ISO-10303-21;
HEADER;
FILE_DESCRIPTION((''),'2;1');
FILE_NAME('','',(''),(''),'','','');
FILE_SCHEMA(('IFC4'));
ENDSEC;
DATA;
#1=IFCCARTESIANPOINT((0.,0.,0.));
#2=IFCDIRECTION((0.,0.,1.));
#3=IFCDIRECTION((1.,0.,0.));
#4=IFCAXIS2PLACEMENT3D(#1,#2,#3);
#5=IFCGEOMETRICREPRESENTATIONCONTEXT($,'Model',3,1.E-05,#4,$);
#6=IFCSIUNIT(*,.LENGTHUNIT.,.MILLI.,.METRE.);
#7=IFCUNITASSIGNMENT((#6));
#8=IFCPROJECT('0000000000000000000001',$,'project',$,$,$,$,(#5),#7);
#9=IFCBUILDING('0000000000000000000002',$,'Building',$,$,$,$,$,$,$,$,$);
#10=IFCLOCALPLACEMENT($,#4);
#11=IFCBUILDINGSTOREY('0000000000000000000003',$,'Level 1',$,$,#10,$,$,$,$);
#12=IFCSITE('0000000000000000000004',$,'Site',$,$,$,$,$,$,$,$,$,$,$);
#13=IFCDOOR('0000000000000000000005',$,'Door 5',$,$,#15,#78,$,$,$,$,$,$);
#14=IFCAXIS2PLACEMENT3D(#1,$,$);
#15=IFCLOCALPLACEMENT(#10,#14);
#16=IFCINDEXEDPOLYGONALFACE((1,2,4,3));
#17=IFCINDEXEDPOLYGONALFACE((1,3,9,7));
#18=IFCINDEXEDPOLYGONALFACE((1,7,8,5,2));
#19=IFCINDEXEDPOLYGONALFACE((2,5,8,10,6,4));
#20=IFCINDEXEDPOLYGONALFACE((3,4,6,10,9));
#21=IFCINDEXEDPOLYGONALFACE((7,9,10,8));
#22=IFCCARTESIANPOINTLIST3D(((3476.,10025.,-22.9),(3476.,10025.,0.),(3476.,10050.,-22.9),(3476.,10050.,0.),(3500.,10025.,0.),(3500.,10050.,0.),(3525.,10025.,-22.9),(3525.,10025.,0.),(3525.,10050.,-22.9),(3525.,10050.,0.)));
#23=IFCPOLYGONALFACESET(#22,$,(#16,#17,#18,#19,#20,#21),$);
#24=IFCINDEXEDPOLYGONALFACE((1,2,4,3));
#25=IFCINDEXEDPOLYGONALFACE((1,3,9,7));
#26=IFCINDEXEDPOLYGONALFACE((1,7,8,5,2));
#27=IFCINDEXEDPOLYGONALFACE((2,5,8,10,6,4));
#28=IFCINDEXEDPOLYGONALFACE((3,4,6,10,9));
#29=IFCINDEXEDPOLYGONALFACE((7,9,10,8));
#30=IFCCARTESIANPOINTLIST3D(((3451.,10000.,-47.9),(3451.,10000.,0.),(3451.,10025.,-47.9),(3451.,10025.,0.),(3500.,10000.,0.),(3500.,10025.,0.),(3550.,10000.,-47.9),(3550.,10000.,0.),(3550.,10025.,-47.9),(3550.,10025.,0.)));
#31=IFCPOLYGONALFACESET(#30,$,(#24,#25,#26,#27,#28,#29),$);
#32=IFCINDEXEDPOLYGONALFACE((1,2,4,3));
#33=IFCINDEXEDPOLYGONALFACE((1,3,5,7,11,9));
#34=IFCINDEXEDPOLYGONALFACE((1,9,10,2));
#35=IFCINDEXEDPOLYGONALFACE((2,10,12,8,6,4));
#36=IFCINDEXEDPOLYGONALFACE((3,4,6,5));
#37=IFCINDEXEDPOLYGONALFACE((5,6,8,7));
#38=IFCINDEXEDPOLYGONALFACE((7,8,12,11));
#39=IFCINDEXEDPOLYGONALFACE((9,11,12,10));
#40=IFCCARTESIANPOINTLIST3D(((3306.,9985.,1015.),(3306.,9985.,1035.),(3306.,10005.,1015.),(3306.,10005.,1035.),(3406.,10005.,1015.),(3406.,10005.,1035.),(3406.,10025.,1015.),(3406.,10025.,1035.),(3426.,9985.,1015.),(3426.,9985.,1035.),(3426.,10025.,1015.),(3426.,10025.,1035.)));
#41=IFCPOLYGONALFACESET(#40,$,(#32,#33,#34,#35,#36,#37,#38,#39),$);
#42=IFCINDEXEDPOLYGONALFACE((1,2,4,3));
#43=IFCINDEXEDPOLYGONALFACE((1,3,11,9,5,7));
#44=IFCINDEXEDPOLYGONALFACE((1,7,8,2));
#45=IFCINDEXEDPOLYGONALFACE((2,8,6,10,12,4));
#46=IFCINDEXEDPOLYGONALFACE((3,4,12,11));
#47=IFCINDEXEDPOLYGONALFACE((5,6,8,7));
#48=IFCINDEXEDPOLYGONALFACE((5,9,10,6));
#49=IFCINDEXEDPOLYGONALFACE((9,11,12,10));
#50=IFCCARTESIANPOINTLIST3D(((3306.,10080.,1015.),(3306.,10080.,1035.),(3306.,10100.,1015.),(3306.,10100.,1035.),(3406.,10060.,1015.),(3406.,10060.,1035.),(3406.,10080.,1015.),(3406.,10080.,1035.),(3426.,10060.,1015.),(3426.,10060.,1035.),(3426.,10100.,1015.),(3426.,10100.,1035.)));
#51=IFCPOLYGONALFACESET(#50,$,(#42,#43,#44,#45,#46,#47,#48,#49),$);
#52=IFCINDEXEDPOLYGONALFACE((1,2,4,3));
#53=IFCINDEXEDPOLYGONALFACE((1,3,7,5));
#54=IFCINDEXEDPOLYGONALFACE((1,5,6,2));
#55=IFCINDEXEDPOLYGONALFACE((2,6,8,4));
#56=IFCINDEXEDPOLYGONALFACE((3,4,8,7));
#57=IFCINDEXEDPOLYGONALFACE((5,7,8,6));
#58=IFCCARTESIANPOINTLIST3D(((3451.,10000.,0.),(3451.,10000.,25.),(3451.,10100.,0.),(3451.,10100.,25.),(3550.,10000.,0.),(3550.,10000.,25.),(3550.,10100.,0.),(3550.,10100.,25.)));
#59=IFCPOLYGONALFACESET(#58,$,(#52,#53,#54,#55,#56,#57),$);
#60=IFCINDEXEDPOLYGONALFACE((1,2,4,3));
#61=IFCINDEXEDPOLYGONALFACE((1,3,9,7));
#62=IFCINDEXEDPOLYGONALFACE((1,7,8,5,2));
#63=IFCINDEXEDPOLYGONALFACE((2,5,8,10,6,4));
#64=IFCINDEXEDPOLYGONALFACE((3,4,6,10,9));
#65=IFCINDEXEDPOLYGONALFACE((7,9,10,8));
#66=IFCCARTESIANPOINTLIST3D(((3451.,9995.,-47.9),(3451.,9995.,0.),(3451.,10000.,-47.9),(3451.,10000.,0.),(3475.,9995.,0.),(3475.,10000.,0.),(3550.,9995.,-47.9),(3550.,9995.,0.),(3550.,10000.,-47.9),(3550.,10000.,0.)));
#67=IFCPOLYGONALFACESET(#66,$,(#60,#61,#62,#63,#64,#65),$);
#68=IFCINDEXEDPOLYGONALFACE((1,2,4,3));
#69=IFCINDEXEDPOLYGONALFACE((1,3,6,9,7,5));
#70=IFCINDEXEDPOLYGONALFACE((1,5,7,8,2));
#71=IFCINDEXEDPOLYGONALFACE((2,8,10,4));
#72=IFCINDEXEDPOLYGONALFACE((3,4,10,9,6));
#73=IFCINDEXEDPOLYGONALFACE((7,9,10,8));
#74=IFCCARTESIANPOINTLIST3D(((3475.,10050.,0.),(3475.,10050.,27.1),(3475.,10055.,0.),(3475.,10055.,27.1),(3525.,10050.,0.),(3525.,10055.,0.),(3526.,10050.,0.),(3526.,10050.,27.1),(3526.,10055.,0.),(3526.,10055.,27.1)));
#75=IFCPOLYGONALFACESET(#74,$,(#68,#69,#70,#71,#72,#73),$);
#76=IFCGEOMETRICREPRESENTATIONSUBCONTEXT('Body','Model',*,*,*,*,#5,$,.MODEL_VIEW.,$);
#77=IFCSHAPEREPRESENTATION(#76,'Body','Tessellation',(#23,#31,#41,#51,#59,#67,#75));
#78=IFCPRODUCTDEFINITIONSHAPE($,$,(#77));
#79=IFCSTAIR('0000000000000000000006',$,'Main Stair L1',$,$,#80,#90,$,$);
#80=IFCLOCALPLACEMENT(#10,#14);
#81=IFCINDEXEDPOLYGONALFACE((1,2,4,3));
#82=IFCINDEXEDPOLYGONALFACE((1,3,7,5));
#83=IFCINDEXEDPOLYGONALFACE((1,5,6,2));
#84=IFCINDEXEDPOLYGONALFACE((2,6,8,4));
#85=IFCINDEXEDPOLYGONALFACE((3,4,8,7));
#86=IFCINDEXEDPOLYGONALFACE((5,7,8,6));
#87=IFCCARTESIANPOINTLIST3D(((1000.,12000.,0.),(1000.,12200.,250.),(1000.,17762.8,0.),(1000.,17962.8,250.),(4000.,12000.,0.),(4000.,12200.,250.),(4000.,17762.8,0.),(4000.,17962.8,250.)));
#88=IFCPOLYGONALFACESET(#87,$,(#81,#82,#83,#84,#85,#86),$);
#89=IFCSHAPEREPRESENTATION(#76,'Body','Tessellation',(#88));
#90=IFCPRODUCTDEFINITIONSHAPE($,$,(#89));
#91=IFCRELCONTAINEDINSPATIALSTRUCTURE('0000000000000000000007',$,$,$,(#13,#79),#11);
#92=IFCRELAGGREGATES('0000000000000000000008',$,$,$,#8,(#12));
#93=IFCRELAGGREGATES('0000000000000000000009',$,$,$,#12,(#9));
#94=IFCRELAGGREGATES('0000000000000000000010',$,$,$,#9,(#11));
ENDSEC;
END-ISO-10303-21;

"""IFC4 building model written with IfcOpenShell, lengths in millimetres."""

from ifc_helpers import new_model, si_unit, frame, origin_with_axes, place, context, subcontext, project, spatial, line, indexed_curve, outline, extrude, element, save


model = new_model("IFC4")

# Units and contexts
model_context = context("Model", 3, precision=1e-05, world=origin_with_axes())
body_context = subcontext(model_context, "Body", "Model", "MODEL_VIEW")
ifc_project = project(units=[si_unit("LENGTHUNIT", "METRE", prefix="MILLI")], contexts=[model_context])

# Site, building, storey
site = spatial("IfcSite", under=ifc_project, Name="Site")
building = spatial("IfcBuilding", under=site, Name="Building")
storey_placement = place(None, origin_with_axes())
storey = spatial("IfcBuildingStorey", under=building, at=storey_placement, Name="Level 1")

# Door
door_1_placement = place(storey_placement, frame((3500.0, 10000.0, 0.0), z_axis=(0.0, 0.0, 1.0), x_axis=(1.0, 0.0, 0.0)))
element("IfcDoor", 1, at=door_1_placement, inside=storey, Name="Door 5", context=body_context, shape_type="SweptSolid", body=[
    extrude(outline(indexed_curve([(0.0, 0.0), (0.0, 2.1), (1.0, 2.1), (1.0, 0.0), (-24.0, 0.0), (-24.0, -22.9), (25.0, -22.9), (25.0, 0.0)], segments=[line(1, 2, 3, 4, 5, 6, 7, 8, 1)])), frame((0.0, 25.0, 0.0), z_axis=(0.0, -1.0, 0.0), x_axis=(1.0, 0.0, 0.0)), (0.0, 0.0, -1.0), 25.0),
    extrude(outline(indexed_curve([(0.0, 0.0), (0.0, 2.1), (1.0, 2.1), (1.0, 0.0), (-49.0, 0.0), (-49.0, -47.9), (50.0, -47.9), (50.0, 0.0)], segments=[line(1, 2, 3, 4, 5, 6, 7, 8, 1)])), frame((0.0, 0.0, 0.0), z_axis=(0.0, -1.0, 0.0), x_axis=(1.0, 0.0, 0.0)), (0.0, 0.0, -1.0), 25.0),
    extrude(outline(indexed_curve([(0.0, 0.0), (-49.0, 0.0), (-49.0, 35.0), (0.0, 35.0)], segments=[line(1, 2, 3, 4, 1)])), frame((25.0, 25.0, 25.0), z_axis=(0.0, 0.0, 1.0), x_axis=(1.0, 0.0, 0.0)), (0.0, 0.0, 1.0), -47.9),
    extrude(outline(indexed_curve([(0.0, 0.0), (0.0, -40.0), (-120.0, -40.0), (-120.0, -20.0), (-20.0, -20.0), (-20.0, 0.0)], segments=[line(1, 2, 3, 4, 5, 6, 1)])), frame((-74.0, 25.0, 1015.0), z_axis=(0.0, 0.0, 1.0), x_axis=(1.0, 0.0, 0.0)), (0.0, 0.0, 1.0), 20.0),
    extrude(outline(indexed_curve([(0.0, 0.0), (0.0, 40.0), (-120.0, 40.0), (-120.0, 20.0), (-20.0, 20.0), (-20.0, 0.0)], segments=[line(1, 2, 3, 4, 5, 6, 1)])), frame((-74.0, 60.0, 1015.0), z_axis=(0.0, 0.0, 1.0), x_axis=(1.0, 0.0, 0.0)), (0.0, 0.0, 1.0), 20.0),
    extrude(outline(indexed_curve([(0.0, 0.0), (-99.0, 0.0), (-99.0, 100.0), (0.0, 100.0)], segments=[line(1, 2, 3, 4, 1)])), frame((50.0, 0.0, 0.0), z_axis=(0.0, 0.0, 1.0), x_axis=(1.0, 0.0, 0.0)), (0.0, 0.0, 1.0), 25.0),
    extrude(outline(indexed_curve([(0.0, 0.0), (0.0, 27.1), (51.0, 27.1), (51.0, 0.0), (-24.0, 0.0), (-24.0, -47.9), (75.0, -47.9), (75.0, 0.0)], segments=[line(1, 2, 3, 4, 5, 6, 7, 8, 1)])), frame((-25.0, -5.0, 0.0), z_axis=(0.0, -1.0, 0.0), x_axis=(1.0, 0.0, 0.0)), (0.0, 0.0, -1.0), 5.0),
    extrude(outline(indexed_curve([(0.0, 0.0), (0.0, 27.1), (51.0, 27.1), (51.0, 0.0), (1.0, 0.0), (1.0, -22.9), (50.0, -22.9), (50.0, 0.0)], segments=[line(1, 2, 3, 4, 5, 6, 7, 8, 1)])), frame((-25.0, 50.0, 0.0), z_axis=(0.0, -1.0, 0.0), x_axis=(1.0, 0.0, 0.0)), (0.0, 0.0, -1.0), 5.0),
])

# Stair
stair_placement = place(storey_placement, frame((1000.0, 12000.0, 0.0), z_axis=(0.0, 0.0, 1.0), x_axis=(1.0, 0.0, 0.0)))
element("IfcStair", 2, at=stair_placement, inside=storey, Name="Main Stair L1", context=body_context, shape_type="SweptSolid", body=[
    extrude(outline(indexed_curve([(0.0, 0.0), (3000.0, 0.0), (3000.0, 5762.8), (0.0, 5762.8), (0.0, 0.0)])), None, (0.0, 0.624695, 0.780869), 320.2),
])

save(model, "model.ifc")
